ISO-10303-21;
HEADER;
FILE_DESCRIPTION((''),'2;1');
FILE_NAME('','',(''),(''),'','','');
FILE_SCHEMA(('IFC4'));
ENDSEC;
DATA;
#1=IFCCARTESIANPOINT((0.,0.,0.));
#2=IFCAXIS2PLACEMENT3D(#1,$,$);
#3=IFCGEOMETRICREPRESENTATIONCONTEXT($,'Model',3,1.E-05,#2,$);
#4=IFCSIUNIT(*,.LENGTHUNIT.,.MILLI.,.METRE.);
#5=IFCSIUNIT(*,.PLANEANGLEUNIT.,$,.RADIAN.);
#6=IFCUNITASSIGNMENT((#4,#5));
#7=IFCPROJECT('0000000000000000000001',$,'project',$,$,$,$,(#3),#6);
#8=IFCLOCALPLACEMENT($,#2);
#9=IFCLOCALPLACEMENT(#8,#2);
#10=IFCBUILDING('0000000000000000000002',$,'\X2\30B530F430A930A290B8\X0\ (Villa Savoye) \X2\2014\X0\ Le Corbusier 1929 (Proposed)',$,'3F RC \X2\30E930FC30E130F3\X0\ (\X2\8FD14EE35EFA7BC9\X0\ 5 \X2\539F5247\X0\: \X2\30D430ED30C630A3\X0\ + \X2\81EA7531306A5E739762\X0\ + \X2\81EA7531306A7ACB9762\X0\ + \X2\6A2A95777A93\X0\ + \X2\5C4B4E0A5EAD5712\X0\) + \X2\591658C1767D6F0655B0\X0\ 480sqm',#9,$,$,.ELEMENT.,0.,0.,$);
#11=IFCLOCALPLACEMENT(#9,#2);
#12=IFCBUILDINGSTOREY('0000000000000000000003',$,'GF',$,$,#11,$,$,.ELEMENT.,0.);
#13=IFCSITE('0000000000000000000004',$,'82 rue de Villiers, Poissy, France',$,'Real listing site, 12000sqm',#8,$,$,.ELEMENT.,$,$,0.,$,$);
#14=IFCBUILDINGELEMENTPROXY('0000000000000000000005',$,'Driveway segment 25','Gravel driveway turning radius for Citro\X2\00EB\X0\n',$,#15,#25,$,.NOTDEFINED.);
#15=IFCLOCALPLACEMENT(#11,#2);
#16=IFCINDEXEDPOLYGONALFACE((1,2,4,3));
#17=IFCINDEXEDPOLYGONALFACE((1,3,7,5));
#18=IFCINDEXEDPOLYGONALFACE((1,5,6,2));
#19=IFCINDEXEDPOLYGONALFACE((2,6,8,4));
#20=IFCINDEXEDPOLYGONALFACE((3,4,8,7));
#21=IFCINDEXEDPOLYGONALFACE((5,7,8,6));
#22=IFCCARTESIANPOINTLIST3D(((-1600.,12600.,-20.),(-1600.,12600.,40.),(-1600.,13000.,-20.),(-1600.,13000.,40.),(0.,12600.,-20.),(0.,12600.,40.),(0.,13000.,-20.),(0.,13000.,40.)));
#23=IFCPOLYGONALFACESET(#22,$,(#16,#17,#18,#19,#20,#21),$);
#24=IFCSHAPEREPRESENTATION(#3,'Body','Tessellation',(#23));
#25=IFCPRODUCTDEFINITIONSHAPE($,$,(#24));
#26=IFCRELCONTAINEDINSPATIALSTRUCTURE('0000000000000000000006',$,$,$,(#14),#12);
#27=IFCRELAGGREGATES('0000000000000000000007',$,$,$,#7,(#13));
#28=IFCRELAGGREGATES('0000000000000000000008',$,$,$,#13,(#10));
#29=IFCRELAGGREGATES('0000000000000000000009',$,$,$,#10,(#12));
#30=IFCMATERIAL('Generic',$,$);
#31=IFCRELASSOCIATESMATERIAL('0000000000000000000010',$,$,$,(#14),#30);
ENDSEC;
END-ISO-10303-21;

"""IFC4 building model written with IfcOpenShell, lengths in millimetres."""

from ifc_helpers import new_model, si_unit, frame, frame_2d, origin, place, context, project, spatial, rectangle, extrude, material, element, save


model = new_model("IFC4")

# Units and contexts
model_context = context("Model", 3, precision=1e-05, world=origin())
ifc_project = project(units=[si_unit("LENGTHUNIT", "METRE", prefix="MILLI"), si_unit("PLANEANGLEUNIT", "RADIAN")], contexts=[model_context])

# Site, building, storey
site_placement = place(None, origin())
site = spatial("IfcSite", under=ifc_project, at=site_placement, Name="82 rue de Villiers, Poissy, France", ObjectType="Real listing site, 12000sqm", CompositionType="ELEMENT", RefElevation=0.0)
building_placement = place(site_placement, origin())
building = spatial("IfcBuilding", under=site, at=building_placement, Name="サヴォア邸 (Villa Savoye) — Le Corbusier 1929 (Proposed)", ObjectType="3F RC ラーメン (近代建築 5 原則: ピロティ + 自由な平面 + 自由な立面 + 横長窓 + 屋上庭園) + 外壁白漆喰 480sqm", CompositionType="ELEMENT", ElevationOfRefHeight=0.0, ElevationOfTerrain=0.0)
storey_placement = place(building_placement, origin())
storey = spatial("IfcBuildingStorey", under=building, at=storey_placement, Name="GF", CompositionType="ELEMENT", Elevation=0.0)

# Shared definitions
ifc_material_1 = material(Name="Generic")

# Building element proxy
proxy_1_placement = place(storey_placement, frame((-800.0, 6300.0, -10.0)))
element("IfcBuildingElementProxy", 1, at=proxy_1_placement, inside=storey, material=ifc_material_1, Name="Driveway segment 25", Description="Gravel driveway turning radius for Citroën", PredefinedType="NOTDEFINED", context=model_context, shape_type="SweptSolid", body=[
    extrude(rectangle(XDim=1600.0, YDim=400.0, at=frame_2d((800.0, 200.0))), frame((-800.0, 6300.0, -10.0)), (0.0, 0.0, 1.0), 60.0),
])

save(model, "model.ifc")
